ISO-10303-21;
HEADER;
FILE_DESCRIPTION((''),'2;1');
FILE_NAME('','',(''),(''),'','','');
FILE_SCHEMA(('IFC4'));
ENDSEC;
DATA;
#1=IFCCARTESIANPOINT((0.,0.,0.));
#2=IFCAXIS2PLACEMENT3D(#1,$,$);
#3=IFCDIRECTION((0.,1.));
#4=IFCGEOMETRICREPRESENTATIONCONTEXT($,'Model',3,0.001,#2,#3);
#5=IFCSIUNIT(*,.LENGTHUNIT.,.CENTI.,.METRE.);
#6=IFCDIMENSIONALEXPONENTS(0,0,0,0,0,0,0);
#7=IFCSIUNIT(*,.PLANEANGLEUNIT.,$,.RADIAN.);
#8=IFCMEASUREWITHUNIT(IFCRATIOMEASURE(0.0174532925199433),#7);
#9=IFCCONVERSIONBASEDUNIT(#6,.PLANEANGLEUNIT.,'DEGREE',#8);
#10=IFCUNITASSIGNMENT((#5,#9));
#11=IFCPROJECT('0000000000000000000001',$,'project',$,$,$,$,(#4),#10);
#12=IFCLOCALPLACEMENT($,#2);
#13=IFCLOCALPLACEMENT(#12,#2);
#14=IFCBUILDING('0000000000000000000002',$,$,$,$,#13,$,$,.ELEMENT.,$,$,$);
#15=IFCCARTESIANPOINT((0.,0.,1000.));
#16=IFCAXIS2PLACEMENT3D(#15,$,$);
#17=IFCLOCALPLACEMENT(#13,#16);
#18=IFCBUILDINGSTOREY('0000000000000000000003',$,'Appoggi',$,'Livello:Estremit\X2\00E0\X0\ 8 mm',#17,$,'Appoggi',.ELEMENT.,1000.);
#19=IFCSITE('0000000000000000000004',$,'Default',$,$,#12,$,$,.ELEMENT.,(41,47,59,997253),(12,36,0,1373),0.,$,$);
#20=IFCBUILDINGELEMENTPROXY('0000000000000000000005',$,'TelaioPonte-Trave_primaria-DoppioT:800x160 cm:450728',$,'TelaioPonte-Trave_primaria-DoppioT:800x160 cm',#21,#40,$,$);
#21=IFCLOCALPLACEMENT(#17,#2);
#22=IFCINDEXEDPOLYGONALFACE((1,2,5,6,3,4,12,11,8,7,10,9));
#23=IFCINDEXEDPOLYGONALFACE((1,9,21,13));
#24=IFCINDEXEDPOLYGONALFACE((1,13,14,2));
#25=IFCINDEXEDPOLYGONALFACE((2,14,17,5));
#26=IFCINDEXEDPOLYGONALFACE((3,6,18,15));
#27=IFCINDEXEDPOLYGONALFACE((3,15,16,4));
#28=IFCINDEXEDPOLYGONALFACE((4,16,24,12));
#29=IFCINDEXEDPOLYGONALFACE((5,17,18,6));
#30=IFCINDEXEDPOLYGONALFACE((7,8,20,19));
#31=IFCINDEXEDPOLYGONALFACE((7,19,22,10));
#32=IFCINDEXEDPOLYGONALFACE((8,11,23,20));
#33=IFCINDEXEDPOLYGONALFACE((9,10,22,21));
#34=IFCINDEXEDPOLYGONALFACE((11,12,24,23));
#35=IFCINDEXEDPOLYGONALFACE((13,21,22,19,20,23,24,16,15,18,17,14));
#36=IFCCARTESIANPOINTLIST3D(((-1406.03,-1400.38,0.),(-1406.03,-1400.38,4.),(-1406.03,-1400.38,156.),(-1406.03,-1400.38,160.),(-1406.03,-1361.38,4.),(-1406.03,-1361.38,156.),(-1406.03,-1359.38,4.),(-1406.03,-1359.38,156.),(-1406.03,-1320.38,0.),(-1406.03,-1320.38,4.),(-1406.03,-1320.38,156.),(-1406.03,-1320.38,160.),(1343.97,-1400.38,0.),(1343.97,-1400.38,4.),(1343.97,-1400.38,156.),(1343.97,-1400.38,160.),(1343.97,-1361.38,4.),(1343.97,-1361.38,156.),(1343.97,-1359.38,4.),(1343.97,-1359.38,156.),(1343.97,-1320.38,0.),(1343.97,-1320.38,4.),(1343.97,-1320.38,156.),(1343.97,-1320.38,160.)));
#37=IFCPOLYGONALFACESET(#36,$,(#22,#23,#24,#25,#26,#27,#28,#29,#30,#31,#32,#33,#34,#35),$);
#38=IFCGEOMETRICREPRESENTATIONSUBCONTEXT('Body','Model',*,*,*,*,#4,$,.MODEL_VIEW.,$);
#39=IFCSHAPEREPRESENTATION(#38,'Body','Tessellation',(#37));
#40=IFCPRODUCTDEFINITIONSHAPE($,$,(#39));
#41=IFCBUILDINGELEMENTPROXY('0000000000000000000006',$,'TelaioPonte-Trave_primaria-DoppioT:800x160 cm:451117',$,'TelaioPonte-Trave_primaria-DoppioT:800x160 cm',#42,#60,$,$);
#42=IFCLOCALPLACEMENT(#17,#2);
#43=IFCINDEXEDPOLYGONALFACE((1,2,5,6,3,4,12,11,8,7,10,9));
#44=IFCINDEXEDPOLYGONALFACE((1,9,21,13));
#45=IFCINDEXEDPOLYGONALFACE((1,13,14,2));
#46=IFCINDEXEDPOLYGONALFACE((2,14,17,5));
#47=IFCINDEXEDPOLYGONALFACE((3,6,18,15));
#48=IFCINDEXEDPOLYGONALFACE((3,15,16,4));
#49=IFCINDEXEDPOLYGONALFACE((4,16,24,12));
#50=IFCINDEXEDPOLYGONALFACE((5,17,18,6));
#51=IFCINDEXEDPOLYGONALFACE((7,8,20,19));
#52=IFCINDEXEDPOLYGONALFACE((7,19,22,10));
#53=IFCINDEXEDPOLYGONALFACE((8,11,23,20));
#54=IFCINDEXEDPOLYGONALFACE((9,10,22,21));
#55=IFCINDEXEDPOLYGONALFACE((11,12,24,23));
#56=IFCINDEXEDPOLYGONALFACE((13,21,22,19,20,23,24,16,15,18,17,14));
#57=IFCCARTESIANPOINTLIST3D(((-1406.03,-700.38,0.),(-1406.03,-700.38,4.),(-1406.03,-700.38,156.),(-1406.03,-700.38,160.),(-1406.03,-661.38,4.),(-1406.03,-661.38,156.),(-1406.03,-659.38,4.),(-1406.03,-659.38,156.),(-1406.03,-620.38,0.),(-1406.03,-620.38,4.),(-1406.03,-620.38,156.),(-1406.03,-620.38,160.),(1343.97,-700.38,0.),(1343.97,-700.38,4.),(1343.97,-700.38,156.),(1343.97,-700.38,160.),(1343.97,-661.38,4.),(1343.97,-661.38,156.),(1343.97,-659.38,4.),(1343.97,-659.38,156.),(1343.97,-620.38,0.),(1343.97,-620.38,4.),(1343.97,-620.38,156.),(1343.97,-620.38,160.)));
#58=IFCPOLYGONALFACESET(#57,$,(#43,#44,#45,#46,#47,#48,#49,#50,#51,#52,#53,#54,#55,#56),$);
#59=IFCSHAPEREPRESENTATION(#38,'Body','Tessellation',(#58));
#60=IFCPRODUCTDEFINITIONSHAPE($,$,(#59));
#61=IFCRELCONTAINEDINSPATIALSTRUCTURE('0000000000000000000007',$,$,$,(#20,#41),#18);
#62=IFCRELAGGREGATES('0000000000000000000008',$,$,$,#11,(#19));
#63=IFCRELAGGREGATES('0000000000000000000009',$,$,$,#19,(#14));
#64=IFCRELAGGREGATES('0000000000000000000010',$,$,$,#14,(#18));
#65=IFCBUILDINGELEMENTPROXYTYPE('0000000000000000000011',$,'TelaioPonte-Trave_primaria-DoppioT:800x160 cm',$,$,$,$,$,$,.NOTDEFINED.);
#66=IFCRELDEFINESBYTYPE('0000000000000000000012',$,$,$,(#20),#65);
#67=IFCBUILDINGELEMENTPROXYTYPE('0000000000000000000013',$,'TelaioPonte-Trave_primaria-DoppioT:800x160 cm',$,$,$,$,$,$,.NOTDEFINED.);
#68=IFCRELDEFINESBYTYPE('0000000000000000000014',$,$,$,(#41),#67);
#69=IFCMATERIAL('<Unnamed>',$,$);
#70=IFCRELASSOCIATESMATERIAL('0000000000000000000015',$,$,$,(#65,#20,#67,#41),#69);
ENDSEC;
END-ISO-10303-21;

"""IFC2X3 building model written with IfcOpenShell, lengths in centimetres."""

from ifc_helpers import new_model, entity, si_unit, converted_unit, direction, frame, frame_2d, origin, place, context, subcontext, project, spatial, i_section, extrude, source, transform, mapped, material, type_object, type_shapes, element, save


model = new_model("IFC2X3")

# Units and contexts
model_context = context("Model", 3, precision=0.001, world=origin(), true_north=direction((0.0, 1.0)))
body_context = subcontext(model_context, "Body", "Model", "MODEL_VIEW")
ifc_project = project(units=[si_unit("LENGTHUNIT", "METRE", prefix="CENTI"), converted_unit("PLANEANGLEUNIT", "DEGREE", entity("IfcRatioMeasure", 0.0174532925199433), si_unit("PLANEANGLEUNIT", "RADIAN"), dimensions=[0, 0, 0, 0, 0, 0, 0])], contexts=[model_context])

# Site, building, storey
site_placement = place(None, origin())
site = spatial("IfcSite", under=ifc_project, at=site_placement, Name="Default", CompositionType="ELEMENT", RefLatitude=(41, 47, 59, 997253), RefLongitude=(12, 36, 0, 1373), RefElevation=0.0)
building_placement = place(site_placement, origin())
building = spatial("IfcBuilding", under=site, at=building_placement, CompositionType="ELEMENT")
storey_placement = place(building_placement, frame((0.0, 0.0, 1000.0)))
storey = spatial("IfcBuildingStorey", under=building, at=storey_placement, Name="Appoggi", ObjectType="Livello:Estremità 8 mm", LongName="Appoggi", CompositionType="ELEMENT", Elevation=1000.0)

# Building element proxies
ifc_material = material(Name="<Unnamed>")
building_element_proxy_type_1 = type_object("IfcBuildingElementProxyType", Name="TelaioPonte-Trave_primaria-DoppioT:800x160 cm", PredefinedType="NOTDEFINED", material=ifc_material)
shared_shape_1 = source(origin(), body_context, "Body", "SweptSolid", [
    extrude(i_section(OverallWidth=80.0, OverallDepth=160.0, WebThickness=2.0, FlangeThickness=4.0, at=frame_2d((0.0, 0.0), x_axis=(0.0, 1.0))), frame((0.0, 0.0, 80.0), z_axis=(1.0, 0.0, 0.0), x_axis=(0.0, 0.0, 1.0)), (0.0, 0.0, 1.0), 2750.0),
])
type_shapes(building_element_proxy_type_1, [shared_shape_1])
proxy_1_placement = place(storey_placement, frame((-1406.03, -1360.38, 0.0)))
element("IfcBuildingElementProxy", 1, at=proxy_1_placement, inside=storey, type_object=building_element_proxy_type_1, material=ifc_material, Name="TelaioPonte-Trave_primaria-DoppioT:800x160 cm:450728", ObjectType="TelaioPonte-Trave_primaria-DoppioT:800x160 cm", context=body_context, shape_type="MappedRepresentation", body=[
    mapped(shared_shape_1, transform((0.0, 0.0, 0.0), scale=1.0)),
])
building_element_proxy_type_2 = type_object("IfcBuildingElementProxyType", Name="TelaioPonte-Trave_primaria-DoppioT:800x160 cm", PredefinedType="NOTDEFINED", material=ifc_material)
shared_shape_2 = source(origin(), body_context, "Body", "SweptSolid", [
    extrude(i_section(OverallWidth=80.0, OverallDepth=160.0, WebThickness=2.0, FlangeThickness=4.0, at=frame_2d((0.0, 0.0), x_axis=(1.0, 0.0))), frame((0.0, 0.0, 80.0), z_axis=(1.0, 0.0, 0.0), x_axis=(0.0, 1.0, 0.0)), (0.0, 0.0, 1.0), 2750.0),
])
type_shapes(building_element_proxy_type_2, [shared_shape_2])
proxy_2_placement = place(storey_placement, frame((-1406.03, -660.38, 0.0)))
element("IfcBuildingElementProxy", 2, at=proxy_2_placement, inside=storey, type_object=building_element_proxy_type_2, material=ifc_material, Name="TelaioPonte-Trave_primaria-DoppioT:800x160 cm:451117", ObjectType="TelaioPonte-Trave_primaria-DoppioT:800x160 cm", context=body_context, shape_type="MappedRepresentation", body=[
    mapped(shared_shape_2, transform((0.0, 0.0, 0.0), scale=1.0)),
])

save(model, "model.ifc")
